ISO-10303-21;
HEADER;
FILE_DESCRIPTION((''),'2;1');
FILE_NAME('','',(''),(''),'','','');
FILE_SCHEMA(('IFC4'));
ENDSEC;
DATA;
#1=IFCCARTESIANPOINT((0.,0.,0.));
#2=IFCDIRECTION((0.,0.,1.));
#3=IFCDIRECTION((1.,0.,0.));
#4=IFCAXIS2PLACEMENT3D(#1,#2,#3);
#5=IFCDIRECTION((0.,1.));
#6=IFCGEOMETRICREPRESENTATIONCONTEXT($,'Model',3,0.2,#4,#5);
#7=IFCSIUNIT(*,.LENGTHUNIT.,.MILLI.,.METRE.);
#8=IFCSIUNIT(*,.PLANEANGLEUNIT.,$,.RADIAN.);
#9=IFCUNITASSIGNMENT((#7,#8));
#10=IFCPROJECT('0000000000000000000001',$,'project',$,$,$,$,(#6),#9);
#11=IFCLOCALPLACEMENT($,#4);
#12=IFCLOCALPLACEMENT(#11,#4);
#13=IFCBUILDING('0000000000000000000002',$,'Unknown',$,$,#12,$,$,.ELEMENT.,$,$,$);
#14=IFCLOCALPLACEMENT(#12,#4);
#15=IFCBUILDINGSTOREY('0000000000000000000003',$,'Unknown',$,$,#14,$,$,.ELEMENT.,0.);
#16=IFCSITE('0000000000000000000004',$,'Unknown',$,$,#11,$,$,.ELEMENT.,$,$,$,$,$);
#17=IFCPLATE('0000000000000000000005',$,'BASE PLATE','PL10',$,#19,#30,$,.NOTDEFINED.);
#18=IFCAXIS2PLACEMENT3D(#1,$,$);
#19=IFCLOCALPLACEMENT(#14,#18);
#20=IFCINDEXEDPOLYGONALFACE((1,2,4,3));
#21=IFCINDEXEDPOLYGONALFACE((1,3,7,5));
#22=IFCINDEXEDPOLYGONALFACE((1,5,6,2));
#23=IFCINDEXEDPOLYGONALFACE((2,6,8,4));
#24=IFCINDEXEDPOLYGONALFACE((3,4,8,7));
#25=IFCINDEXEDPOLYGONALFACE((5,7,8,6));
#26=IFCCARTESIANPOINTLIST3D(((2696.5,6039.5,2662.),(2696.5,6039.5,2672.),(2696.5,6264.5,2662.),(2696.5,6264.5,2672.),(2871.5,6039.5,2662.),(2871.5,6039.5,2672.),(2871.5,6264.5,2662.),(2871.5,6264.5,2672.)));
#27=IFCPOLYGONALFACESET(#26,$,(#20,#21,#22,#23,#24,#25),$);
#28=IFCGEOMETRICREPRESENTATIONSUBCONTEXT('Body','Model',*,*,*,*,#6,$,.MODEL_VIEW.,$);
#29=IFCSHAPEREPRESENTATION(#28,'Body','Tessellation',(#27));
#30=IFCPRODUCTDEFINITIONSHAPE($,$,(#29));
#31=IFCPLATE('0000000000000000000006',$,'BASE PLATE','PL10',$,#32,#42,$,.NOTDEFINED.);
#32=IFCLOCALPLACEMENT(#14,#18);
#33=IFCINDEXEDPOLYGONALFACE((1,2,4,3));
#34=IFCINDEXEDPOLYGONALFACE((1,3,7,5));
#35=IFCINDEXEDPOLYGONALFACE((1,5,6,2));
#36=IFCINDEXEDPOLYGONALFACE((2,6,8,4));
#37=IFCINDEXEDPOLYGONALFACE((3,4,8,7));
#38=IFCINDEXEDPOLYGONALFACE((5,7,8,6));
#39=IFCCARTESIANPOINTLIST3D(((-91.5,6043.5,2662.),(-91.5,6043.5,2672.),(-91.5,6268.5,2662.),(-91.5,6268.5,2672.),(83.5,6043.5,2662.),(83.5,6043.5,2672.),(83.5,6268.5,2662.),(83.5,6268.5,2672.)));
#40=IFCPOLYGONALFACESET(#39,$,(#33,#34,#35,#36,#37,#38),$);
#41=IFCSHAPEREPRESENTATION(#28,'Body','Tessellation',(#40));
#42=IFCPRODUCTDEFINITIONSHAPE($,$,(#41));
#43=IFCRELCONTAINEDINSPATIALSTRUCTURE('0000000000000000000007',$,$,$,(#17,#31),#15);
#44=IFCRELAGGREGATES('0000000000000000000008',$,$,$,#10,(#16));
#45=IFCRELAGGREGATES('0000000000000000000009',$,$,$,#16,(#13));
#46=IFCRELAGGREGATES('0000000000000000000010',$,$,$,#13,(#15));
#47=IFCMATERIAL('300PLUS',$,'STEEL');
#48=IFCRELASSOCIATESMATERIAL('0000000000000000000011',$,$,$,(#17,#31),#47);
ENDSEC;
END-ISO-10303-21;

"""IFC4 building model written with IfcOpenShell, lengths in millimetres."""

from ifc_helpers import new_model, si_unit, direction, frame, origin_with_axes, place, context, subcontext, project, spatial, line, indexed_curve, outline, extrude, material, element, save


model = new_model("IFC4")

# Units and contexts
model_context = context("Model", 3, precision=0.2, world=origin_with_axes(), true_north=direction((0.0, 1.0)))
body_context = subcontext(model_context, "Body", "Model", "MODEL_VIEW")
ifc_project = project(units=[si_unit("LENGTHUNIT", "METRE", prefix="MILLI"), si_unit("PLANEANGLEUNIT", "RADIAN")], contexts=[model_context])

# Site, building, storey
site_placement = place(None, origin_with_axes())
site = spatial("IfcSite", under=ifc_project, at=site_placement, Name="Unknown", CompositionType="ELEMENT")
building_placement = place(site_placement, origin_with_axes())
building = spatial("IfcBuilding", under=site, at=building_placement, Name="Unknown", CompositionType="ELEMENT")
storey_placement = place(building_placement, origin_with_axes())
storey = spatial("IfcBuildingStorey", under=building, at=storey_placement, Name="Unknown", CompositionType="ELEMENT", Elevation=0.0)

# Shared definitions
ifc_material_1 = material(Name="300PLUS", Category="STEEL")

# Plates
for number, where, z_axis, x_axis, name in (
    (1, (2871.5, 6039.5, 2667.0), (0.0, 0.0, 1.0), (0.0, 1.0, 0.0), "BASE PLATE"),
    (2, (83.5, 6043.5, 2667.0), (0.0, 0.0, 1.0), (0.0, 1.0, 0.0), "BASE PLATE"),
):
    element("IfcPlate", number, at=place(storey_placement, frame(where, z_axis=z_axis, x_axis=x_axis)), inside=storey, material=ifc_material_1, Name=name, Description="PL10", PredefinedType="NOTDEFINED", context=body_context, shape_type="SolidModel", body=[
        extrude(outline(indexed_curve([(0.0, 0.0), (225.0, 0.0), (225.0, 175.0), (0.0, 175.0)], segments=[line(1, 2, 3, 4, 1)])), frame((0.0, 0.0, 5.0), z_axis=(0.0, 0.0, 1.0), x_axis=(1.0, 0.0, 0.0)), (0.0, 0.0, -1.0), 10.0),
    ])

save(model, "model.ifc")
